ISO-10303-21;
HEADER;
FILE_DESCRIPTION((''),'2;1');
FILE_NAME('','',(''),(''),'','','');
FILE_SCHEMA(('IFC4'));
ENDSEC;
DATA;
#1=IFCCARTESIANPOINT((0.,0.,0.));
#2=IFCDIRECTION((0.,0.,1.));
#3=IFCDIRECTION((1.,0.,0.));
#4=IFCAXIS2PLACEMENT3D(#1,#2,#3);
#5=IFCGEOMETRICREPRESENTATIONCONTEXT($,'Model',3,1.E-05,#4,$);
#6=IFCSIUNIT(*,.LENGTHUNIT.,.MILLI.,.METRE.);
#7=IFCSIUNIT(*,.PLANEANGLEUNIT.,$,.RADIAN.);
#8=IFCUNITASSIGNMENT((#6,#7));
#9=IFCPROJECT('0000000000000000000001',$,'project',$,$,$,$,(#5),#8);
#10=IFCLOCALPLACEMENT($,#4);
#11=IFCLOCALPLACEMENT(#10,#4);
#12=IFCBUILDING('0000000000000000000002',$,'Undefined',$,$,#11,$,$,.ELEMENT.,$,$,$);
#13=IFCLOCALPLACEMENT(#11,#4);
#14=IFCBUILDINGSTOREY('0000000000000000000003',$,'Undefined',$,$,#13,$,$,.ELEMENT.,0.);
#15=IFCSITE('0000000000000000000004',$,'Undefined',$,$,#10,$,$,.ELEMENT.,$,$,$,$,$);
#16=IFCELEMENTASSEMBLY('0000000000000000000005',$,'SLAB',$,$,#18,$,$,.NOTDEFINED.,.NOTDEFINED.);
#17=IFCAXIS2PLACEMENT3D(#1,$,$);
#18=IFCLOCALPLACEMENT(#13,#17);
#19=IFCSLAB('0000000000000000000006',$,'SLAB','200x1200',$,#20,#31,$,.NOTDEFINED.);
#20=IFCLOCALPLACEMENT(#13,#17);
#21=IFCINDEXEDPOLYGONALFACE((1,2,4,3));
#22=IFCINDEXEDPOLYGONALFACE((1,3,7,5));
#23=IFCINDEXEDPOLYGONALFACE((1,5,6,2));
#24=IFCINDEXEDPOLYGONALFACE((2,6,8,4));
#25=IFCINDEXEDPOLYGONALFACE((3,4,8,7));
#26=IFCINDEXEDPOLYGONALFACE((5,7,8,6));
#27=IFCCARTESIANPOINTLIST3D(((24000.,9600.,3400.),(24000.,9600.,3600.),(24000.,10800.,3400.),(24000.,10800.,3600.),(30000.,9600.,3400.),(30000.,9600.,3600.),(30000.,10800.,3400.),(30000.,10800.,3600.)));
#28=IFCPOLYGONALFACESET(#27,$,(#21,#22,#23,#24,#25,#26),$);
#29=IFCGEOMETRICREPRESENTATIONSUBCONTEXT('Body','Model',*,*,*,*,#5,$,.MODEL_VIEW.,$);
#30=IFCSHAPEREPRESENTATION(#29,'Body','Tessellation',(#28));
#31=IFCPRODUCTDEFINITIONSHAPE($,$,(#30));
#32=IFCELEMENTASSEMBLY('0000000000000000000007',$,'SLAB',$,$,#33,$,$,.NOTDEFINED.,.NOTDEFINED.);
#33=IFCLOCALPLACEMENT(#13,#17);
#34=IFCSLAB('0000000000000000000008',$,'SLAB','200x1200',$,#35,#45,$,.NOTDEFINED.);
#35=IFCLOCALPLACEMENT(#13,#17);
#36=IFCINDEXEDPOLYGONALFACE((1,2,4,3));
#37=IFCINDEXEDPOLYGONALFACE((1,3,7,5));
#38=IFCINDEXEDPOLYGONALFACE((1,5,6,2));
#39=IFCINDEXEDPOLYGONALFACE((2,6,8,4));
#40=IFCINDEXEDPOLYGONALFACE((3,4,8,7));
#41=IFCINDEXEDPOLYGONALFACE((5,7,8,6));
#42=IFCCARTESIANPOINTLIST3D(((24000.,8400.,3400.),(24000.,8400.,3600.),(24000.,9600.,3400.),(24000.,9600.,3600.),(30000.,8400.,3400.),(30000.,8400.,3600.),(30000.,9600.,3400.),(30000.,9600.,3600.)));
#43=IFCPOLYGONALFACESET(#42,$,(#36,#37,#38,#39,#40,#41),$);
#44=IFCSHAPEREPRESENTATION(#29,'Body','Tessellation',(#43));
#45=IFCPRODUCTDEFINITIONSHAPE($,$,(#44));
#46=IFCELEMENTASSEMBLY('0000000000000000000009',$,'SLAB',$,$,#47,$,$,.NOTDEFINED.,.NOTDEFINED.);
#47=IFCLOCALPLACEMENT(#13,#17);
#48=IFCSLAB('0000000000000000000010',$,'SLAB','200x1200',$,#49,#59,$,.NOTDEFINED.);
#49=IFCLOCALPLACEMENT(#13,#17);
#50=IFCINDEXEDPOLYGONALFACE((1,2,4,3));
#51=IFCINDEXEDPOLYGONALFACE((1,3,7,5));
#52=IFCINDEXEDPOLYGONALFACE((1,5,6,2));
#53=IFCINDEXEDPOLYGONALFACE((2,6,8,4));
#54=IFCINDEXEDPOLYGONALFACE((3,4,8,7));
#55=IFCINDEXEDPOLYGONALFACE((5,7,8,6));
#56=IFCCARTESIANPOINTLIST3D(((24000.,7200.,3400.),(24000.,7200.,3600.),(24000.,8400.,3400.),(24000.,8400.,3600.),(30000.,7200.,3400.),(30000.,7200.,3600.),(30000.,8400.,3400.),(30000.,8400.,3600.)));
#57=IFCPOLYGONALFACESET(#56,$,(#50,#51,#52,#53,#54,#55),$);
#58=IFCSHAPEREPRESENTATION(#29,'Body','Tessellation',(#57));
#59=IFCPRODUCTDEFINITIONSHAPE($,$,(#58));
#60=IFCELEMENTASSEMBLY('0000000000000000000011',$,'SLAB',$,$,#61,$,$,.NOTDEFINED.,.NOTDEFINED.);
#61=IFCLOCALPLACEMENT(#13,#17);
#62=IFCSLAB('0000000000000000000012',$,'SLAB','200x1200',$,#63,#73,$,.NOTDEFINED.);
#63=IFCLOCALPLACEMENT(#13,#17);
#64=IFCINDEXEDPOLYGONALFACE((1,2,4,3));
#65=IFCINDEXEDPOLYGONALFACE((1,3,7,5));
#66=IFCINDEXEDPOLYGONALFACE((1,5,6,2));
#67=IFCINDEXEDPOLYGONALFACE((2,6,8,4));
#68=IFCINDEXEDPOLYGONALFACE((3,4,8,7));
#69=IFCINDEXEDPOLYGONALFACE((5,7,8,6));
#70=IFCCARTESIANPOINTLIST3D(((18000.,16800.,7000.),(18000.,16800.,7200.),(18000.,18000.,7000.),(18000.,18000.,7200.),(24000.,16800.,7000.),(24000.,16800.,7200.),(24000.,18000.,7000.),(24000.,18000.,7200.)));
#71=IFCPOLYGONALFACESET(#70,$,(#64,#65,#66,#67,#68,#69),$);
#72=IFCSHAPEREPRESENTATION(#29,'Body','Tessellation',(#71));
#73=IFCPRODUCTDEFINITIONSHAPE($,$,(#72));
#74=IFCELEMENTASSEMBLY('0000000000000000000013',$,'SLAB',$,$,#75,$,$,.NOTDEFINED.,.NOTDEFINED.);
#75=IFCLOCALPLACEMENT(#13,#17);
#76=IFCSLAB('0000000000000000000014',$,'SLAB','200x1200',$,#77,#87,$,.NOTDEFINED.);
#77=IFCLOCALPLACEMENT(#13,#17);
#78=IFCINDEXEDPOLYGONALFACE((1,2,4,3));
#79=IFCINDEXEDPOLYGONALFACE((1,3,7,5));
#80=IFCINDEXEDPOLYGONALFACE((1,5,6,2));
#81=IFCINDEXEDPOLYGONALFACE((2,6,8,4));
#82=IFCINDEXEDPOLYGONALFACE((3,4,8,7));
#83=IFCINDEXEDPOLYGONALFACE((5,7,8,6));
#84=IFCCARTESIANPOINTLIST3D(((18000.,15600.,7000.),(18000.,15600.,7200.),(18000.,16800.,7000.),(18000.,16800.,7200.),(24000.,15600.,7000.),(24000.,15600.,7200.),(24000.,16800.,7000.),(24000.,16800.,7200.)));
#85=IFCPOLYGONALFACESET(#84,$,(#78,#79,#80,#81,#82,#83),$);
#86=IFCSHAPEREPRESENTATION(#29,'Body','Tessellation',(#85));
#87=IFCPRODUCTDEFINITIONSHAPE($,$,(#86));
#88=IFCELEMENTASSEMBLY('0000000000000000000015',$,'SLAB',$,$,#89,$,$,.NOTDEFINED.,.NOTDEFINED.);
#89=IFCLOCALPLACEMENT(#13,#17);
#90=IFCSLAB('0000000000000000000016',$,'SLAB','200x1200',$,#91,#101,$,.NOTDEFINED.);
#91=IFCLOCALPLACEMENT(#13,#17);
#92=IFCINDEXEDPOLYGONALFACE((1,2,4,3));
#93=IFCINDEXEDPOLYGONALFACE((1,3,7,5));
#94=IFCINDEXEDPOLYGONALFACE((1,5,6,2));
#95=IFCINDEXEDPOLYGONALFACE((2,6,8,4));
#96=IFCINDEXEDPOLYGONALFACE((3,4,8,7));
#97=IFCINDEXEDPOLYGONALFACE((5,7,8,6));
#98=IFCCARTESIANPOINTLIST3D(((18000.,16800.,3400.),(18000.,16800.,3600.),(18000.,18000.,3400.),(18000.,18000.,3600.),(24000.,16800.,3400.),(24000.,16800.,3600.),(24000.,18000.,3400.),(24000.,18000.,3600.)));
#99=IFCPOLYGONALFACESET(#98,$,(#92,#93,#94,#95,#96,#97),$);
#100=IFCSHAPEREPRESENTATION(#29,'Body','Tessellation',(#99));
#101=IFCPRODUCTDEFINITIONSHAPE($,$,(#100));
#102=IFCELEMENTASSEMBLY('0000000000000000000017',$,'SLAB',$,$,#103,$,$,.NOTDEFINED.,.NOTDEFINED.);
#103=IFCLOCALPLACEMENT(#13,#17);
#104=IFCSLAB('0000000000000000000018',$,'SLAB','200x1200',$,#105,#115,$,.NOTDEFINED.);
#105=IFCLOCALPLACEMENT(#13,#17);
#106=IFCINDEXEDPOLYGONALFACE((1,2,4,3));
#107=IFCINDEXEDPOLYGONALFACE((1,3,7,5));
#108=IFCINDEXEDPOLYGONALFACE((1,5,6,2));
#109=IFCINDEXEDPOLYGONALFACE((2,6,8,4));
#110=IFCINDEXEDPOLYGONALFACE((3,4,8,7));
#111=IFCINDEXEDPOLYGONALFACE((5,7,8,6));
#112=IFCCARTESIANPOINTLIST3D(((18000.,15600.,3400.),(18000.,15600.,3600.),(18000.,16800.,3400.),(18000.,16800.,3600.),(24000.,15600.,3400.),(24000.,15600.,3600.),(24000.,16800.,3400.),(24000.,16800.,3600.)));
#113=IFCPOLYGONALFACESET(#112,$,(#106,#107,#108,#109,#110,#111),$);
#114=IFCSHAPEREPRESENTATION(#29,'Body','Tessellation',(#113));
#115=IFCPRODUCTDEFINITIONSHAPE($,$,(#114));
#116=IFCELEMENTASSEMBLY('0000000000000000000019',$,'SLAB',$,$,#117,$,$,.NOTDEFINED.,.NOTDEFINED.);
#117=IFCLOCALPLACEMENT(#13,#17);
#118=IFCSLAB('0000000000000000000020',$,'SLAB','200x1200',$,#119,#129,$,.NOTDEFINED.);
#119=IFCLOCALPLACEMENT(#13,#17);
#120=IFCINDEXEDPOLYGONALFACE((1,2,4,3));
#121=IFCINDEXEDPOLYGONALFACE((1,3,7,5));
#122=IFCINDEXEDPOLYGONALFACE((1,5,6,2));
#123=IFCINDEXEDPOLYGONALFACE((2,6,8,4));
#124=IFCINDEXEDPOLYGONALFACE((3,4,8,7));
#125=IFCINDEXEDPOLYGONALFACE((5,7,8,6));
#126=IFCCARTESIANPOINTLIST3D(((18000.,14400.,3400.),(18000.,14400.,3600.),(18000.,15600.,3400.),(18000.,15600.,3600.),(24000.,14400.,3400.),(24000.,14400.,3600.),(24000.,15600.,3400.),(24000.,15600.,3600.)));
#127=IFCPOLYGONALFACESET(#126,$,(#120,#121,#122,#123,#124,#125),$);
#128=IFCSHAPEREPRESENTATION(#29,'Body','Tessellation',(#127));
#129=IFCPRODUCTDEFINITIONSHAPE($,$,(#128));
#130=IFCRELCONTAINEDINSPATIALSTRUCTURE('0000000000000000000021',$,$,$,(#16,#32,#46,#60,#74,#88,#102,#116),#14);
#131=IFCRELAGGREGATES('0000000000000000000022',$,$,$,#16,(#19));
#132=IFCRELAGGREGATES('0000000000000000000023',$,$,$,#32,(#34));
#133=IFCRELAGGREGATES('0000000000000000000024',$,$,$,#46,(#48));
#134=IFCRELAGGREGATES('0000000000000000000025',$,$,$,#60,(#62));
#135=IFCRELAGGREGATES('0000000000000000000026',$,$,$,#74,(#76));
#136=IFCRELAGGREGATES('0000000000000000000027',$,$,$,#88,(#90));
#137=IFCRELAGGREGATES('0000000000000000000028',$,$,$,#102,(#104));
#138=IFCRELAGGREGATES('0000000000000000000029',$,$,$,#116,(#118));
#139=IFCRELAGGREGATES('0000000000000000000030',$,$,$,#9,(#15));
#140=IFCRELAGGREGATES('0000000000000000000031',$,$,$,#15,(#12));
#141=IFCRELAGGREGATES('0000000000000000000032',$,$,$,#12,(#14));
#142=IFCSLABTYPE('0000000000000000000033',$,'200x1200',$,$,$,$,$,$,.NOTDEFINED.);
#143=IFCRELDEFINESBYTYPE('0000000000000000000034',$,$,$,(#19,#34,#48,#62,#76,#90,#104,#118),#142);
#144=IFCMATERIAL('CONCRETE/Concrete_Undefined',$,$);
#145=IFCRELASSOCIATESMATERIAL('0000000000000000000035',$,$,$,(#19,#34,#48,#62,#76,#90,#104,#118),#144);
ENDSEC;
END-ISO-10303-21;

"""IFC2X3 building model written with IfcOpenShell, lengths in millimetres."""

from ifc_helpers import new_model, si_unit, frame, origin_with_axes, place, context, subcontext, project, spatial, polyline, outline, extrude, material, type_object, element, aggregate, save


model = new_model("IFC2X3")

# Units and contexts
model_context = context("Model", 3, precision=1e-05, world=origin_with_axes())
body_context = subcontext(model_context, "Body", "Model", "MODEL_VIEW")
ifc_project = project(units=[si_unit("LENGTHUNIT", "METRE", prefix="MILLI"), si_unit("PLANEANGLEUNIT", "RADIAN")], contexts=[model_context])

# Site, building, storey
site_placement = place(None, origin_with_axes())
site = spatial("IfcSite", under=ifc_project, at=site_placement, Name="Undefined", CompositionType="ELEMENT")
building_placement = place(site_placement, origin_with_axes())
building = spatial("IfcBuilding", under=site, at=building_placement, Name="Undefined", CompositionType="ELEMENT")
storey_placement = place(building_placement, origin_with_axes())
storey = spatial("IfcBuildingStorey", under=building, at=storey_placement, Name="Undefined", CompositionType="ELEMENT", Elevation=0.0)

# Shared definitions
ifc_material = material(Name="CONCRETE/Concrete_Undefined")

# Element assemblies, slabs
slab_type = type_object("IfcSlabType", Name="200x1200", PredefinedType="NOTDEFINED")
assembly_1_placement = place(storey_placement, origin_with_axes())
assembly_1 = element("IfcElementAssembly", 1, at=assembly_1_placement, inside=storey, Name="SLAB", AssemblyPlace="NOTDEFINED", PredefinedType="NOTDEFINED")
slab_1_placement = place(assembly_1_placement, frame((30000.0, 9600.0, 3500.0), z_axis=(0.0, 0.0, 1.0), x_axis=(0.0, 1.0, 0.0)))
slab_1 = element("IfcSlab", 2, at=slab_1_placement, type_object=slab_type, material=ifc_material, Name="SLAB", Description="200x1200", PredefinedType="NOTDEFINED", context=body_context, shape_type="SweptSolid", body=[
    extrude(outline(polyline([(0.0, 0.0), (1200.0, 0.0), (1200.0, 6000.0), (0.0, 6000.0), (0.0, 0.0)])), frame((0.0, 0.0, -100.0), z_axis=(0.0, 0.0, 1.0), x_axis=(1.0, 0.0, 0.0)), (0.0, 0.0, 1.0), 200.0),
])
aggregate(assembly_1, [slab_1])
assembly_2_placement = place(storey_placement, origin_with_axes())
assembly_2 = element("IfcElementAssembly", 3, at=assembly_2_placement, inside=storey, Name="SLAB", AssemblyPlace="NOTDEFINED", PredefinedType="NOTDEFINED")
slab_2_placement = place(assembly_2_placement, frame((30000.0, 8400.0, 3500.0), z_axis=(0.0, 0.0, 1.0), x_axis=(0.0, 1.0, 0.0)))
slab_2 = element("IfcSlab", 4, at=slab_2_placement, type_object=slab_type, material=ifc_material, Name="SLAB", Description="200x1200", PredefinedType="NOTDEFINED", context=body_context, shape_type="SweptSolid", body=[
    extrude(outline(polyline([(0.0, 0.0), (1200.0, 0.0), (1200.0, 6000.0), (0.0, 6000.0), (0.0, 0.0)])), frame((0.0, 0.0, -100.0), z_axis=(0.0, 0.0, 1.0), x_axis=(1.0, 0.0, 0.0)), (0.0, 0.0, 1.0), 200.0),
])
aggregate(assembly_2, [slab_2])
assembly_3_placement = place(storey_placement, origin_with_axes())
assembly_3 = element("IfcElementAssembly", 5, at=assembly_3_placement, inside=storey, Name="SLAB", AssemblyPlace="NOTDEFINED", PredefinedType="NOTDEFINED")
slab_3_placement = place(assembly_3_placement, frame((30000.0, 7200.0, 3500.0), z_axis=(0.0, 0.0, 1.0), x_axis=(0.0, 1.0, 0.0)))
slab_3 = element("IfcSlab", 6, at=slab_3_placement, type_object=slab_type, material=ifc_material, Name="SLAB", Description="200x1200", PredefinedType="NOTDEFINED", context=body_context, shape_type="SweptSolid", body=[
    extrude(outline(polyline([(0.0, 0.0), (1200.0, 0.0), (1200.0, 6000.0), (0.0, 6000.0), (0.0, 0.0)])), frame((0.0, 0.0, -100.0), z_axis=(0.0, 0.0, 1.0), x_axis=(1.0, 0.0, 0.0)), (0.0, 0.0, 1.0), 200.0),
])
aggregate(assembly_3, [slab_3])
assembly_4_placement = place(storey_placement, origin_with_axes())
assembly_4 = element("IfcElementAssembly", 7, at=assembly_4_placement, inside=storey, Name="SLAB", AssemblyPlace="NOTDEFINED", PredefinedType="NOTDEFINED")
slab_4_placement = place(assembly_4_placement, frame((24000.0, 16800.0, 7100.0), z_axis=(0.0, 0.0, 1.0), x_axis=(0.0, 1.0, 0.0)))
slab_4 = element("IfcSlab", 8, at=slab_4_placement, type_object=slab_type, material=ifc_material, Name="SLAB", Description="200x1200", PredefinedType="NOTDEFINED", context=body_context, shape_type="SweptSolid", body=[
    extrude(outline(polyline([(0.0, 0.0), (1200.0, 0.0), (1200.0, 6000.0), (0.0, 6000.0), (0.0, 0.0)])), frame((0.0, 0.0, -100.0), z_axis=(0.0, 0.0, 1.0), x_axis=(1.0, 0.0, 0.0)), (0.0, 0.0, 1.0), 200.0),
])
aggregate(assembly_4, [slab_4])
assembly_5_placement = place(storey_placement, origin_with_axes())
assembly_5 = element("IfcElementAssembly", 9, at=assembly_5_placement, inside=storey, Name="SLAB", AssemblyPlace="NOTDEFINED", PredefinedType="NOTDEFINED")
slab_5_placement = place(assembly_5_placement, frame((24000.0, 15600.0, 7100.0), z_axis=(0.0, 0.0, 1.0), x_axis=(0.0, 1.0, 0.0)))
slab_5 = element("IfcSlab", 10, at=slab_5_placement, type_object=slab_type, material=ifc_material, Name="SLAB", Description="200x1200", PredefinedType="NOTDEFINED", context=body_context, shape_type="SweptSolid", body=[
    extrude(outline(polyline([(0.0, 0.0), (1200.0, 0.0), (1200.0, 6000.0), (0.0, 6000.0), (0.0, 0.0)])), frame((0.0, 0.0, -100.0), z_axis=(0.0, 0.0, 1.0), x_axis=(1.0, 0.0, 0.0)), (0.0, 0.0, 1.0), 200.0),
])
aggregate(assembly_5, [slab_5])
assembly_6_placement = place(storey_placement, origin_with_axes())
assembly_6 = element("IfcElementAssembly", 11, at=assembly_6_placement, inside=storey, Name="SLAB", AssemblyPlace="NOTDEFINED", PredefinedType="NOTDEFINED")
slab_6_placement = place(assembly_6_placement, frame((24000.0, 16800.0, 3500.0), z_axis=(0.0, 0.0, 1.0), x_axis=(0.0, 1.0, 0.0)))
slab_6 = element("IfcSlab", 12, at=slab_6_placement, type_object=slab_type, material=ifc_material, Name="SLAB", Description="200x1200", PredefinedType="NOTDEFINED", context=body_context, shape_type="SweptSolid", body=[
    extrude(outline(polyline([(0.0, 0.0), (1200.0, 0.0), (1200.0, 6000.0), (0.0, 6000.0), (0.0, 0.0)])), frame((0.0, 0.0, -100.0), z_axis=(0.0, 0.0, 1.0), x_axis=(1.0, 0.0, 0.0)), (0.0, 0.0, 1.0), 200.0),
])
aggregate(assembly_6, [slab_6])
assembly_7_placement = place(storey_placement, origin_with_axes())
assembly_7 = element("IfcElementAssembly", 13, at=assembly_7_placement, inside=storey, Name="SLAB", AssemblyPlace="NOTDEFINED", PredefinedType="NOTDEFINED")
slab_7_placement = place(assembly_7_placement, frame((24000.0, 15600.0, 3500.0), z_axis=(0.0, 0.0, 1.0), x_axis=(0.0, 1.0, 0.0)))
slab_7 = element("IfcSlab", 14, at=slab_7_placement, type_object=slab_type, material=ifc_material, Name="SLAB", Description="200x1200", PredefinedType="NOTDEFINED", context=body_context, shape_type="SweptSolid", body=[
    extrude(outline(polyline([(0.0, 0.0), (1200.0, 0.0), (1200.0, 6000.0), (0.0, 6000.0), (0.0, 0.0)])), frame((0.0, 0.0, -100.0), z_axis=(0.0, 0.0, 1.0), x_axis=(1.0, 0.0, 0.0)), (0.0, 0.0, 1.0), 200.0),
])
aggregate(assembly_7, [slab_7])
assembly_8_placement = place(storey_placement, origin_with_axes())
assembly_8 = element("IfcElementAssembly", 15, at=assembly_8_placement, inside=storey, Name="SLAB", AssemblyPlace="NOTDEFINED", PredefinedType="NOTDEFINED")
slab_8_placement = place(assembly_8_placement, frame((24000.0, 14400.0, 3500.0), z_axis=(0.0, 0.0, 1.0), x_axis=(0.0, 1.0, 0.0)))
slab_8 = element("IfcSlab", 16, at=slab_8_placement, type_object=slab_type, material=ifc_material, Name="SLAB", Description="200x1200", PredefinedType="NOTDEFINED", context=body_context, shape_type="SweptSolid", body=[
    extrude(outline(polyline([(0.0, 0.0), (1200.0, 0.0), (1200.0, 6000.0), (0.0, 6000.0), (0.0, 0.0)])), frame((0.0, 0.0, -100.0), z_axis=(0.0, 0.0, 1.0), x_axis=(1.0, 0.0, 0.0)), (0.0, 0.0, 1.0), 200.0),
])
aggregate(assembly_8, [slab_8])

save(model, "model.ifc")
